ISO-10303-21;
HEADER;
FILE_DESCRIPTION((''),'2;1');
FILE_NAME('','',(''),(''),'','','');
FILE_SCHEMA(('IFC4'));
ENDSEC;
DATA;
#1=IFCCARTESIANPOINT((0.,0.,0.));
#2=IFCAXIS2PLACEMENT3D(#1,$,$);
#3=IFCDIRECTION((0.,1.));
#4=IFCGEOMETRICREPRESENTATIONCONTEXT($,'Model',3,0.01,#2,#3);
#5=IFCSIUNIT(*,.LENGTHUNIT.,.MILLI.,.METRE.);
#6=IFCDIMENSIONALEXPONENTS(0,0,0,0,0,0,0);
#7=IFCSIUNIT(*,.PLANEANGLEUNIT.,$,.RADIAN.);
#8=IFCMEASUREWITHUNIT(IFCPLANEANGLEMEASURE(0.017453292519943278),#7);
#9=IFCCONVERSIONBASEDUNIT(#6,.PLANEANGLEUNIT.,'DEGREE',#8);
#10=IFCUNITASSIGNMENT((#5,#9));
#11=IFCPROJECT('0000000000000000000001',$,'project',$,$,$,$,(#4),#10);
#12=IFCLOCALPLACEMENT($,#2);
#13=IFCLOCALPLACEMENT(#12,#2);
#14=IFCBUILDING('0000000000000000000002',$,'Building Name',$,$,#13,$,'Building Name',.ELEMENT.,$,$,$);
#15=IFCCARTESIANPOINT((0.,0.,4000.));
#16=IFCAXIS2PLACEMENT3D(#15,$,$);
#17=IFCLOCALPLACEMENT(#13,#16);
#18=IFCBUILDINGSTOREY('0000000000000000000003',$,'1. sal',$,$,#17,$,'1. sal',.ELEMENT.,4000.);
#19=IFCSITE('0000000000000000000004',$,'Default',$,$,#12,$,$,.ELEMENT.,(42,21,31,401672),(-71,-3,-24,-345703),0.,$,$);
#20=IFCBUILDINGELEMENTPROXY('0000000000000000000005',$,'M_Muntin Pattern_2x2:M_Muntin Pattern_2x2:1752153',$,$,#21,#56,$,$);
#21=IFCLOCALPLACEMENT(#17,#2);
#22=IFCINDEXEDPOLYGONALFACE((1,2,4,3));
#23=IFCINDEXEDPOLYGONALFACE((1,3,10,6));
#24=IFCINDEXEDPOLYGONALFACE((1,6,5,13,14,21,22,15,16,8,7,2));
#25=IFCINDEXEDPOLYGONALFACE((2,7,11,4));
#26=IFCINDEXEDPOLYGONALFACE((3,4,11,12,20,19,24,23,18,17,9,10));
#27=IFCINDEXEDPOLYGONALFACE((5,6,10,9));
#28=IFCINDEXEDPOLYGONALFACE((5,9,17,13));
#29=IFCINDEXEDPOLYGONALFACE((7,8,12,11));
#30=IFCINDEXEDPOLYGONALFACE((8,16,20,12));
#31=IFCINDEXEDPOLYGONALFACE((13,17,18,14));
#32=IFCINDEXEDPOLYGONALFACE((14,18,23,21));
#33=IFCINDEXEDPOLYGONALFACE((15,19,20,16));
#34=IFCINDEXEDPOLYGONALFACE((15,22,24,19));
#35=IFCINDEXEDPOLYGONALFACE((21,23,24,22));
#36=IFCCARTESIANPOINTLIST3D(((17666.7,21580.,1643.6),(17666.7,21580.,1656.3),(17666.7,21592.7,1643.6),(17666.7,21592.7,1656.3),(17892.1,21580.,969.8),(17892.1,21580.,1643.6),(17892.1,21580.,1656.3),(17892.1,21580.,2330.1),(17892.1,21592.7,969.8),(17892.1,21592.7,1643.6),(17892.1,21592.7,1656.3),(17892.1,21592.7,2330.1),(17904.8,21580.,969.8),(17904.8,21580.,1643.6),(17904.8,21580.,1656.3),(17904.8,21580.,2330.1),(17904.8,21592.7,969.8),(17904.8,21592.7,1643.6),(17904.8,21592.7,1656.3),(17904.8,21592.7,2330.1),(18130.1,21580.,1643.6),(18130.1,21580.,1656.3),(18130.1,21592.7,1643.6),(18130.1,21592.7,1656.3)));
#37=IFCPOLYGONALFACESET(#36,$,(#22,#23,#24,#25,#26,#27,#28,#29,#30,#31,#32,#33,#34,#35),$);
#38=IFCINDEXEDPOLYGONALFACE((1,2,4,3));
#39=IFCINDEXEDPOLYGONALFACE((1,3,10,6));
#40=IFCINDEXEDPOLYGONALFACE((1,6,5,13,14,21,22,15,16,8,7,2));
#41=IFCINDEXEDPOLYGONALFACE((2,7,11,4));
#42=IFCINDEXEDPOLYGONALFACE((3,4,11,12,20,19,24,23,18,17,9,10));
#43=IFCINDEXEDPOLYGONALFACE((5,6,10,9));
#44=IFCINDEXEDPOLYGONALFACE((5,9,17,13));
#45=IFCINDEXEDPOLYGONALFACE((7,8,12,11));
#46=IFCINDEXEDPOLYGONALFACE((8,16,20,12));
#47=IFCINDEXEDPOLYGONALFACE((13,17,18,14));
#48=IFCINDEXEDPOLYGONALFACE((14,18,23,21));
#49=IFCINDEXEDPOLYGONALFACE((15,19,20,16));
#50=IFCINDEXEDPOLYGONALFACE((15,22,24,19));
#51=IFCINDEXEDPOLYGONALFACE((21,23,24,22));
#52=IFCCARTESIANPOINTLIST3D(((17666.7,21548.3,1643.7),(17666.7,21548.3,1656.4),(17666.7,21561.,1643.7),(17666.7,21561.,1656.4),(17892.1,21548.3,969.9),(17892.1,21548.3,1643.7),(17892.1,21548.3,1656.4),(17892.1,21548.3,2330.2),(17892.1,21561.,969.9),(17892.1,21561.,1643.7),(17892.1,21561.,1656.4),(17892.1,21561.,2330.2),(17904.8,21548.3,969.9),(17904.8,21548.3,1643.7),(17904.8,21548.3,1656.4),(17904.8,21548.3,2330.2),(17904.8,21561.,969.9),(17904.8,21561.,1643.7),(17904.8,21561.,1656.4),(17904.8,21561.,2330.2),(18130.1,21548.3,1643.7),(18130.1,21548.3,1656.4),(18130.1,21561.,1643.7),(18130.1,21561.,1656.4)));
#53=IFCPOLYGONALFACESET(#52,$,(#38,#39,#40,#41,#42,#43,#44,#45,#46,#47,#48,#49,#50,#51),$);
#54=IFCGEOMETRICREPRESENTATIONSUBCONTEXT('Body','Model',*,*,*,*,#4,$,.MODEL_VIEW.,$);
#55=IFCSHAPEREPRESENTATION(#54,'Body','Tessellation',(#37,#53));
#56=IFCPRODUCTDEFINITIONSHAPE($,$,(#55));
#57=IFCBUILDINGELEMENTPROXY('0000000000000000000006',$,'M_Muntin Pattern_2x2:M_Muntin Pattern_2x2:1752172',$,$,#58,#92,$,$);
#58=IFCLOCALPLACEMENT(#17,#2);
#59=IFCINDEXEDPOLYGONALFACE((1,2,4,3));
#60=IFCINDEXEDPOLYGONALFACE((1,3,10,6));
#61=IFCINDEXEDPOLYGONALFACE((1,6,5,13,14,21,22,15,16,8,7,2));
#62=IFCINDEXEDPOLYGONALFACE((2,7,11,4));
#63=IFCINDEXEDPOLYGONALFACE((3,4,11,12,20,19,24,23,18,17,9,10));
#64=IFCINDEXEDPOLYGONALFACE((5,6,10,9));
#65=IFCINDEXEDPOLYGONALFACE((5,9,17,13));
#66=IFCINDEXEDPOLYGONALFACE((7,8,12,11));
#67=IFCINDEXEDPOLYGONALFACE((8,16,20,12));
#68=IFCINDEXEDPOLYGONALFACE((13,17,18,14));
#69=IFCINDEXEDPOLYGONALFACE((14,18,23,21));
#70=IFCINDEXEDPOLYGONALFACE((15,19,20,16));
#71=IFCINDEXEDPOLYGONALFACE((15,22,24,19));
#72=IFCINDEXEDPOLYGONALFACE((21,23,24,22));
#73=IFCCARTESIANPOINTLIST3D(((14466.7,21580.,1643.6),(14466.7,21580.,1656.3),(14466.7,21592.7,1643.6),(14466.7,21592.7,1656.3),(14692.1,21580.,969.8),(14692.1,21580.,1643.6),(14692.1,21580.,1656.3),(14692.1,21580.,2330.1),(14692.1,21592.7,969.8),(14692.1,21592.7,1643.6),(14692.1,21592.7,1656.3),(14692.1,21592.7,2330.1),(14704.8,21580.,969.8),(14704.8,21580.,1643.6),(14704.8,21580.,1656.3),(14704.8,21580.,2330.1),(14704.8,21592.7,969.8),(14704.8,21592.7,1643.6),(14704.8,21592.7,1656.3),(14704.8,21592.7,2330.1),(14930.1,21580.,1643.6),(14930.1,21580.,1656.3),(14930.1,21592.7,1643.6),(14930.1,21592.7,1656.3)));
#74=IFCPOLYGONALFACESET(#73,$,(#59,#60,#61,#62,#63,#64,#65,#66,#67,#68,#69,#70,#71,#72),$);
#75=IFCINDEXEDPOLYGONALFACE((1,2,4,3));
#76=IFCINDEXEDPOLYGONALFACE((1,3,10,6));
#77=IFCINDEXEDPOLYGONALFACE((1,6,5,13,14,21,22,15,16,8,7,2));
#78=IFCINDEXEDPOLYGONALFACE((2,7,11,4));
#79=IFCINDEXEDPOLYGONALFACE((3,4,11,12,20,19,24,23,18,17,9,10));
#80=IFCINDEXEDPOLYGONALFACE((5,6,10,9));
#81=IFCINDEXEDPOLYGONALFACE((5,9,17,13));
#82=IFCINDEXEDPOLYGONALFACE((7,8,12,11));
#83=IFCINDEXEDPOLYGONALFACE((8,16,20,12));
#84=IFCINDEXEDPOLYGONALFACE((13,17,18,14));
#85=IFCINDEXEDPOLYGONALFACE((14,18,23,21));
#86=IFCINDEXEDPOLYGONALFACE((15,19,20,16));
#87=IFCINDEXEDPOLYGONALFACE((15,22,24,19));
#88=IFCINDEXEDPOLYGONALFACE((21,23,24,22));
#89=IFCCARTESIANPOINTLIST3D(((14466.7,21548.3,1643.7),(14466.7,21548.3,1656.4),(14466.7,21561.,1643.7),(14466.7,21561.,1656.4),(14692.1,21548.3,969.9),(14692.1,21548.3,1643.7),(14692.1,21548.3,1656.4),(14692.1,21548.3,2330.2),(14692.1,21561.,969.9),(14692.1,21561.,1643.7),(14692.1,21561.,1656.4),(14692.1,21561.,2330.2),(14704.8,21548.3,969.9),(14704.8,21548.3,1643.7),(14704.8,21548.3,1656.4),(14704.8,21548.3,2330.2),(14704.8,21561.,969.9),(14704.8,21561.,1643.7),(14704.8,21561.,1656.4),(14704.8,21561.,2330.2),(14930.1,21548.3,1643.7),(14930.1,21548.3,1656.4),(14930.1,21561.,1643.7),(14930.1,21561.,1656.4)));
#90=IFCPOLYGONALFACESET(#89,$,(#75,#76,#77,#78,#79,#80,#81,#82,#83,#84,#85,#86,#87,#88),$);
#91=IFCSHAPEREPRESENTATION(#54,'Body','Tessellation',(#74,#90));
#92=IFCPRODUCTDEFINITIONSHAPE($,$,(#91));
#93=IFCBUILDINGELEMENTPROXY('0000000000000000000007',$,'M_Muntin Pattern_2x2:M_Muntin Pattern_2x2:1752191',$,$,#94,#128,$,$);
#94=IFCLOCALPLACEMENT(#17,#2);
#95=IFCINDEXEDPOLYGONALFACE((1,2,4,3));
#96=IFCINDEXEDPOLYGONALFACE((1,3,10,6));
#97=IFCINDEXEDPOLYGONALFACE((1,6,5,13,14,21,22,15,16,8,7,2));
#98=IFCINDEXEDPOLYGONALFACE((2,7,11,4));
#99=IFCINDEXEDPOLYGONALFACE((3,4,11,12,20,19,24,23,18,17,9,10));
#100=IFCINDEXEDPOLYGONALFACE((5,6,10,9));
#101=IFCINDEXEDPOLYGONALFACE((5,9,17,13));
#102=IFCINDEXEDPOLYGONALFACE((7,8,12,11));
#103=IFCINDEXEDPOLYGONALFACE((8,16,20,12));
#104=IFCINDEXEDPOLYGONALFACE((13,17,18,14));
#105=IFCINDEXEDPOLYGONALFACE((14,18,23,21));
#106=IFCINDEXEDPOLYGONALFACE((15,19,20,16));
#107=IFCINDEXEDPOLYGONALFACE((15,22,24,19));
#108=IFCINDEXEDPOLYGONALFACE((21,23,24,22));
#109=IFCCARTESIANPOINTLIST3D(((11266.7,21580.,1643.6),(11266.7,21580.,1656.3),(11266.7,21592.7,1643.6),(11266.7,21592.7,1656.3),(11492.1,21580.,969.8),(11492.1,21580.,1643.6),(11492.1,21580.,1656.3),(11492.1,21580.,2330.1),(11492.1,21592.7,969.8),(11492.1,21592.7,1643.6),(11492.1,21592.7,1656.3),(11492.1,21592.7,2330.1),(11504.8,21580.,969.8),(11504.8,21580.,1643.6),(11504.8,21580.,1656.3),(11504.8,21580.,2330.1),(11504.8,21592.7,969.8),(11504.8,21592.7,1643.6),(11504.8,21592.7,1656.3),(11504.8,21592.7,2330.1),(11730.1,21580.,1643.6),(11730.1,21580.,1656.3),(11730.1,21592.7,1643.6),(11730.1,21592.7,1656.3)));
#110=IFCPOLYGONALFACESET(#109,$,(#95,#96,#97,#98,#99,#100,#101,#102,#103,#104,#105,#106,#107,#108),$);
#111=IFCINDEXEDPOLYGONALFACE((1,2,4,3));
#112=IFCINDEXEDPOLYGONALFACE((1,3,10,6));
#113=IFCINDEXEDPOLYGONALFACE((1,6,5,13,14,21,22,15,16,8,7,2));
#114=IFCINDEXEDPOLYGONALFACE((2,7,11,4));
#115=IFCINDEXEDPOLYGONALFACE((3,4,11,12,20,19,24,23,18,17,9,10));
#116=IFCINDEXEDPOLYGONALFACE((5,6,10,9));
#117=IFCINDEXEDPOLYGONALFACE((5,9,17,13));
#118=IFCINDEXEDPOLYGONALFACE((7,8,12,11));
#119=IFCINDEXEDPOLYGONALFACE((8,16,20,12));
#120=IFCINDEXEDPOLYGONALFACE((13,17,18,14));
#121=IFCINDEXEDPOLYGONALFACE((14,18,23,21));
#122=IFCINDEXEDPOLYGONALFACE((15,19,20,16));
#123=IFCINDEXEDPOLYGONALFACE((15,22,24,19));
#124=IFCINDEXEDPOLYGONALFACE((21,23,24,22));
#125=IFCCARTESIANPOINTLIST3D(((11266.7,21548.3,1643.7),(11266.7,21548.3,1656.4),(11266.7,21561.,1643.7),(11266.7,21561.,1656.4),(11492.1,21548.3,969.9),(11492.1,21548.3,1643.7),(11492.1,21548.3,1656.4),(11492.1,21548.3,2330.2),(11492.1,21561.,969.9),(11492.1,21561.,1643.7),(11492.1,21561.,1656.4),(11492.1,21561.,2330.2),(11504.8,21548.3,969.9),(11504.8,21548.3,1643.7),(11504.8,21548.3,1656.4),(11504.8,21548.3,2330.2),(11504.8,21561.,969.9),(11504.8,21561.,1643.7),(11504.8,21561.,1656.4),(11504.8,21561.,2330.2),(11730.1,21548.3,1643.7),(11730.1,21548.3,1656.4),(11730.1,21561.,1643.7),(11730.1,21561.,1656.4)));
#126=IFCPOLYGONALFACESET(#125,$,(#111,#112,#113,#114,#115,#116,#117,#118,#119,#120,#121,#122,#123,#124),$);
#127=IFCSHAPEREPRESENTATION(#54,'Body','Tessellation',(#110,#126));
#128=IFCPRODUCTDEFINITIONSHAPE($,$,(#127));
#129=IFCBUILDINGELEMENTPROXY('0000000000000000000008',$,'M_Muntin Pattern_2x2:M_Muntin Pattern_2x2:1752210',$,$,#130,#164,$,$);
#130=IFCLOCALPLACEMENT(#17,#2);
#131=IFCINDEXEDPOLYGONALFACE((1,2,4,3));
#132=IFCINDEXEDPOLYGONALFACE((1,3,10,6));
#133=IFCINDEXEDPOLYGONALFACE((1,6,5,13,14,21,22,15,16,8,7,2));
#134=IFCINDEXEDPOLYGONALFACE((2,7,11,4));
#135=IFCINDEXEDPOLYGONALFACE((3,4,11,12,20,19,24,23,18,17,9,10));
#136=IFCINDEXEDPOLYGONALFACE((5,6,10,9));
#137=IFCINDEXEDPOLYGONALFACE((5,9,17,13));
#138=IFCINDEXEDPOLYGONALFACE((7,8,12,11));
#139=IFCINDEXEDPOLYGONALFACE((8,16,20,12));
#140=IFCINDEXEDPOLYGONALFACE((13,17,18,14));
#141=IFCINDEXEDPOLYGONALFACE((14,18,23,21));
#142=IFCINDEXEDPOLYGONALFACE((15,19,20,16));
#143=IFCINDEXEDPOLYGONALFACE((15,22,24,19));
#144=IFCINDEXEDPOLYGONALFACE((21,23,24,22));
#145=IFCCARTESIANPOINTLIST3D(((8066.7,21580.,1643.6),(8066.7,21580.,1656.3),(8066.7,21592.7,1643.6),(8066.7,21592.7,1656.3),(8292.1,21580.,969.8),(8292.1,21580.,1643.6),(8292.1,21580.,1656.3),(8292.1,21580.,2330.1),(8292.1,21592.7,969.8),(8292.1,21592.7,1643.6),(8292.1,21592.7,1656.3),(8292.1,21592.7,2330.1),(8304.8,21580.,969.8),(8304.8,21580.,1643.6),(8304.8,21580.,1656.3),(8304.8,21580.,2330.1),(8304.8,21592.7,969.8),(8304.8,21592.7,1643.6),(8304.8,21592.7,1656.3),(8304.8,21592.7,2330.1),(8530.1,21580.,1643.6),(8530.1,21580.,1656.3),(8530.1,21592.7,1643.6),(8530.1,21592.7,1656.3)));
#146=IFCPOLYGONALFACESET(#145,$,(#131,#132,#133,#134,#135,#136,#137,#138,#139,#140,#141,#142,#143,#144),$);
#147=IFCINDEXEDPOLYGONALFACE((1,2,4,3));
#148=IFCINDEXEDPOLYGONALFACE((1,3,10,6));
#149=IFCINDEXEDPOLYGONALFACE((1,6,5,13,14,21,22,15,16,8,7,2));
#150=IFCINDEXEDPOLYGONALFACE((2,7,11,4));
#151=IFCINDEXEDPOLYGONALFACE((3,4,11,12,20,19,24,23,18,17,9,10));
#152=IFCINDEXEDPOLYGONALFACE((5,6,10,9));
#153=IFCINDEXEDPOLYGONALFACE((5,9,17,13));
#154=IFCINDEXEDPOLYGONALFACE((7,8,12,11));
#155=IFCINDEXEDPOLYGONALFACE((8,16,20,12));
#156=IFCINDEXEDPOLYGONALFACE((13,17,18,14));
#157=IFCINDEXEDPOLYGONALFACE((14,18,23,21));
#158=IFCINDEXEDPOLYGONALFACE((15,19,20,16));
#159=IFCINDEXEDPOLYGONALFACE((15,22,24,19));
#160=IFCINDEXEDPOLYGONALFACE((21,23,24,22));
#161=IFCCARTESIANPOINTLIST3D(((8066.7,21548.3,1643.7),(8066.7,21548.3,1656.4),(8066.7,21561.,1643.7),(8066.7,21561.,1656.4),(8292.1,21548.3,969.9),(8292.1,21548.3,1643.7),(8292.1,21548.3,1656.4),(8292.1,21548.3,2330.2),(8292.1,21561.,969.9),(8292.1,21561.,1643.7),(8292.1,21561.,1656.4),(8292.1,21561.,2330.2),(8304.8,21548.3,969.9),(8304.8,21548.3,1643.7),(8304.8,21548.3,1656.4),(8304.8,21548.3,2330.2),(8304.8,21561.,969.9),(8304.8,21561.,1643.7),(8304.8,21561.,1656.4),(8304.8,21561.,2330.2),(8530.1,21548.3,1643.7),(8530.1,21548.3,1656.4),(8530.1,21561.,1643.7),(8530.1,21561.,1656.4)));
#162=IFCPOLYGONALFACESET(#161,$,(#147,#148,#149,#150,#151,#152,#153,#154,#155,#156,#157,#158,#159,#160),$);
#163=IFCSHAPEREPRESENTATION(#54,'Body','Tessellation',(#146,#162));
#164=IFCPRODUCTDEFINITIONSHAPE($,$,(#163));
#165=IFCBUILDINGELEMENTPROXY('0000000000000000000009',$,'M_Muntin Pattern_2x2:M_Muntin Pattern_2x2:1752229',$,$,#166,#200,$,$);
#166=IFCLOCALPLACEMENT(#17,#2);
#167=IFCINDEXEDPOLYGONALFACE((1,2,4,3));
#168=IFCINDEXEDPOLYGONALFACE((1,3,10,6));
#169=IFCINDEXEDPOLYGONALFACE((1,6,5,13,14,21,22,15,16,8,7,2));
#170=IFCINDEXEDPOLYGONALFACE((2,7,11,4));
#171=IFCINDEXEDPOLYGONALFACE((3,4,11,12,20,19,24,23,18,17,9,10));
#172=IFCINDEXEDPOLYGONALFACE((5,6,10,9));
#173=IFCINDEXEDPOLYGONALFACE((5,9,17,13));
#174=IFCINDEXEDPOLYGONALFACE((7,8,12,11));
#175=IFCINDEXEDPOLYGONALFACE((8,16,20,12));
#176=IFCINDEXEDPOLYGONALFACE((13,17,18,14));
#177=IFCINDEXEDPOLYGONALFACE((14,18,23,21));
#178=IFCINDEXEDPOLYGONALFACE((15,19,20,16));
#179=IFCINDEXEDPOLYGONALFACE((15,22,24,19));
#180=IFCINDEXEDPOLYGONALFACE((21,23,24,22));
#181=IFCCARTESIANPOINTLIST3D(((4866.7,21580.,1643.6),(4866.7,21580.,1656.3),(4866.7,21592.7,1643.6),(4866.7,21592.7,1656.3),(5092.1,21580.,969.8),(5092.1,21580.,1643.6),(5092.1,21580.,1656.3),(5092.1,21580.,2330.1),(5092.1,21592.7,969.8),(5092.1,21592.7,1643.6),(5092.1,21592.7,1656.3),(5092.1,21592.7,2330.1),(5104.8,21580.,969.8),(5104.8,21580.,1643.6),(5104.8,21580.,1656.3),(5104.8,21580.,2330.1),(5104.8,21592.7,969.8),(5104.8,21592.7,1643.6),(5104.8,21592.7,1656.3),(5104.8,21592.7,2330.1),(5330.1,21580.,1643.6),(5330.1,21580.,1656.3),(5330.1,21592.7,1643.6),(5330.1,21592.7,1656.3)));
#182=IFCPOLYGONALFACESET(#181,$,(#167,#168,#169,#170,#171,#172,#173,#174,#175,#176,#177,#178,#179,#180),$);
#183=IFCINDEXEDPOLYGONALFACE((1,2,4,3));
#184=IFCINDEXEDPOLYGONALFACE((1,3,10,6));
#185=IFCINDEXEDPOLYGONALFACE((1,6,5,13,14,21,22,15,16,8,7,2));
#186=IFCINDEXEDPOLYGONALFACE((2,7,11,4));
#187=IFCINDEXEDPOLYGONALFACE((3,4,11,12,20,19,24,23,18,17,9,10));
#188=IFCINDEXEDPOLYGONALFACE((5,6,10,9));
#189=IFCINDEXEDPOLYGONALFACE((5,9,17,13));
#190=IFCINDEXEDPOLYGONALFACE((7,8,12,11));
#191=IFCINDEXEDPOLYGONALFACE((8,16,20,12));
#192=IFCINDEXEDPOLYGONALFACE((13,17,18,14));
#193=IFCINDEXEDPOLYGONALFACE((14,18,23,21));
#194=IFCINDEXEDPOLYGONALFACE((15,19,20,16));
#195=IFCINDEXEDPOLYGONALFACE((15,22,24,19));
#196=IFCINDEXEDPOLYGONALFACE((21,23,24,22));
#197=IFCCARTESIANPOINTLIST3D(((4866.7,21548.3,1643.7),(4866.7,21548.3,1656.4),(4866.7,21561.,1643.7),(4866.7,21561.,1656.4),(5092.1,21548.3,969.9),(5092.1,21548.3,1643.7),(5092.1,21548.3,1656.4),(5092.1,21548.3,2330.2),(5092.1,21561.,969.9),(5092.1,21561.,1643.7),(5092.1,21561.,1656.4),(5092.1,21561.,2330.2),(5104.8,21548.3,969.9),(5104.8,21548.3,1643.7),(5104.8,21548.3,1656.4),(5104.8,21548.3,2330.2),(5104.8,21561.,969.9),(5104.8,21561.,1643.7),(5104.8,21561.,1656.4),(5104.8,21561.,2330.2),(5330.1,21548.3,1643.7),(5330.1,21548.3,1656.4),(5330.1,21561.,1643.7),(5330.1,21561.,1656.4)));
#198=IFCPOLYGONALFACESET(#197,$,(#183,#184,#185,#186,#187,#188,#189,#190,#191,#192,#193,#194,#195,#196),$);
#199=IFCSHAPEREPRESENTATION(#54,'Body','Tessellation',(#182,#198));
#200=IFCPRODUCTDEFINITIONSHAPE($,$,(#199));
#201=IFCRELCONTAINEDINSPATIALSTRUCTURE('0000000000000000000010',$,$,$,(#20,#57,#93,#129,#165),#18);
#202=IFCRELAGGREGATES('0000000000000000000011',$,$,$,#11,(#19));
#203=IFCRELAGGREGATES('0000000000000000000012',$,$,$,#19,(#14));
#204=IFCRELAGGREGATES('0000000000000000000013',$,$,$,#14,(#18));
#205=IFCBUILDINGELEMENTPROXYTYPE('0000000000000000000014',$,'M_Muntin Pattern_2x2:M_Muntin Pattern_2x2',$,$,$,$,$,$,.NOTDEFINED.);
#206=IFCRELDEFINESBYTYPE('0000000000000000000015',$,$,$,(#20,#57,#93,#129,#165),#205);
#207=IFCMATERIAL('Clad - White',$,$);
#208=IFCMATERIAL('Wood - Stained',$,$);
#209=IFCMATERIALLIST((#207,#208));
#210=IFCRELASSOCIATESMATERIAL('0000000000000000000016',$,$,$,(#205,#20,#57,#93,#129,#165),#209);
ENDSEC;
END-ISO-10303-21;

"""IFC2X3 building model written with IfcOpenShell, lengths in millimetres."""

from ifc_helpers import new_model, entity, si_unit, converted_unit, direction, frame, origin, place, context, subcontext, project, spatial, polyline, outline, extrude, source, transform, mapped, material, material_list, type_object, type_shapes, element, save


model = new_model("IFC2X3")

# Units and contexts
model_context = context("Model", 3, precision=0.01, world=origin(), true_north=direction((0.0, 1.0)))
body_context = subcontext(model_context, "Body", "Model", "MODEL_VIEW")
ifc_project = project(units=[si_unit("LENGTHUNIT", "METRE", prefix="MILLI"), converted_unit("PLANEANGLEUNIT", "DEGREE", entity("IfcPlaneAngleMeasure", 0.017453292519943278), si_unit("PLANEANGLEUNIT", "RADIAN"), dimensions=[0, 0, 0, 0, 0, 0, 0])], contexts=[model_context])

# Site, building, storey
site_placement = place(None, origin())
site = spatial("IfcSite", under=ifc_project, at=site_placement, Name="Default", CompositionType="ELEMENT", RefLatitude=(42, 21, 31, 401672), RefLongitude=(-71, -3, -24, -345703), RefElevation=0.0)
building_placement = place(site_placement, origin())
building = spatial("IfcBuilding", under=site, at=building_placement, Name="Building Name", LongName="Building Name", CompositionType="ELEMENT")
storey_placement = place(building_placement, frame((0.0, 0.0, 4000.0)))
storey = spatial("IfcBuildingStorey", under=building, at=storey_placement, Name="1. sal", LongName="1. sal", CompositionType="ELEMENT", Elevation=4000.0)

# Building element proxies
ifc_material_1 = material(Name="Clad - White")
ifc_material_2 = material(Name="Wood - Stained")
ifc_material_list = material_list([ifc_material_1, ifc_material_2])
building_element_proxy_type_1 = type_object("IfcBuildingElementProxyType", Name="M_Muntin Pattern_2x2:M_Muntin Pattern_2x2", PredefinedType="NOTDEFINED", material=ifc_material_list)
shared_shape_1 = source(origin(), body_context, "Body", "SweptSolid", [
    extrude(outline(polyline([(6.4, -6.4), (680.1, -6.4), (680.1, 6.3), (6.4, 6.3), (6.4, 231.7), (-6.3, 231.7), (-6.3, 6.3), (-680.2, 6.3), (-680.2, -6.4), (-6.3, -6.4), (-6.3, -231.7), (6.4, -231.7), (6.4, -6.4)])), frame((0.0, -22.2, 680.1), z_axis=(0.0, 1.0, 0.0), x_axis=(0.0, 0.0, 1.0)), (0.0, 0.0, 1.0), 12.7),
    extrude(outline(polyline([(6.4, -6.4), (680.2, -6.4), (680.2, 6.3), (6.4, 6.3), (6.4, 231.7), (-6.3, 231.7), (-6.3, 6.3), (-680.2, 6.3), (-680.2, -6.4), (-6.3, -6.4), (-6.3, -231.7), (6.4, -231.7), (6.4, -6.4)])), frame((0.0, 9.5, 680.2), z_axis=(0.0, 1.0, 0.0), x_axis=(0.0, 0.0, 1.0)), (0.0, 0.0, 1.0), 12.7),
])
type_shapes(building_element_proxy_type_1, [shared_shape_1])
for number, where, z_axis, x_axis, name in (
    (1, (17898.4, 21570.5, 969.9), (0.0, 0.0, 1.0), (-1.0, 0.0, 0.0), "M_Muntin Pattern_2x2:M_Muntin Pattern_2x2:1752153"),
    (2, (14698.4, 21570.5, 969.9), (0.0, 0.0, 1.0), (-1.0, 0.0, 0.0), "M_Muntin Pattern_2x2:M_Muntin Pattern_2x2:1752172"),
    (3, (11498.4, 21570.5, 969.9), (0.0, 0.0, 1.0), (-1.0, 0.0, 0.0), "M_Muntin Pattern_2x2:M_Muntin Pattern_2x2:1752191"),
    (4, (8298.4, 21570.5, 969.9), (0.0, 0.0, 1.0), (-1.0, 0.0, 0.0), "M_Muntin Pattern_2x2:M_Muntin Pattern_2x2:1752210"),
    (5, (5098.4, 21570.5, 969.9), (0.0, 0.0, 1.0), (-1.0, 0.0, 0.0), "M_Muntin Pattern_2x2:M_Muntin Pattern_2x2:1752229"),
):
    element("IfcBuildingElementProxy", number, at=place(storey_placement, frame(where, z_axis=z_axis, x_axis=x_axis)), inside=storey, type_object=building_element_proxy_type_1, material=ifc_material_list, Name=name, context=body_context, shape_type="MappedRepresentation", body=[
        mapped(shared_shape_1, transform((0.0, 0.0, 0.0), scale=1.0)),
    ])

save(model, "model.ifc")
